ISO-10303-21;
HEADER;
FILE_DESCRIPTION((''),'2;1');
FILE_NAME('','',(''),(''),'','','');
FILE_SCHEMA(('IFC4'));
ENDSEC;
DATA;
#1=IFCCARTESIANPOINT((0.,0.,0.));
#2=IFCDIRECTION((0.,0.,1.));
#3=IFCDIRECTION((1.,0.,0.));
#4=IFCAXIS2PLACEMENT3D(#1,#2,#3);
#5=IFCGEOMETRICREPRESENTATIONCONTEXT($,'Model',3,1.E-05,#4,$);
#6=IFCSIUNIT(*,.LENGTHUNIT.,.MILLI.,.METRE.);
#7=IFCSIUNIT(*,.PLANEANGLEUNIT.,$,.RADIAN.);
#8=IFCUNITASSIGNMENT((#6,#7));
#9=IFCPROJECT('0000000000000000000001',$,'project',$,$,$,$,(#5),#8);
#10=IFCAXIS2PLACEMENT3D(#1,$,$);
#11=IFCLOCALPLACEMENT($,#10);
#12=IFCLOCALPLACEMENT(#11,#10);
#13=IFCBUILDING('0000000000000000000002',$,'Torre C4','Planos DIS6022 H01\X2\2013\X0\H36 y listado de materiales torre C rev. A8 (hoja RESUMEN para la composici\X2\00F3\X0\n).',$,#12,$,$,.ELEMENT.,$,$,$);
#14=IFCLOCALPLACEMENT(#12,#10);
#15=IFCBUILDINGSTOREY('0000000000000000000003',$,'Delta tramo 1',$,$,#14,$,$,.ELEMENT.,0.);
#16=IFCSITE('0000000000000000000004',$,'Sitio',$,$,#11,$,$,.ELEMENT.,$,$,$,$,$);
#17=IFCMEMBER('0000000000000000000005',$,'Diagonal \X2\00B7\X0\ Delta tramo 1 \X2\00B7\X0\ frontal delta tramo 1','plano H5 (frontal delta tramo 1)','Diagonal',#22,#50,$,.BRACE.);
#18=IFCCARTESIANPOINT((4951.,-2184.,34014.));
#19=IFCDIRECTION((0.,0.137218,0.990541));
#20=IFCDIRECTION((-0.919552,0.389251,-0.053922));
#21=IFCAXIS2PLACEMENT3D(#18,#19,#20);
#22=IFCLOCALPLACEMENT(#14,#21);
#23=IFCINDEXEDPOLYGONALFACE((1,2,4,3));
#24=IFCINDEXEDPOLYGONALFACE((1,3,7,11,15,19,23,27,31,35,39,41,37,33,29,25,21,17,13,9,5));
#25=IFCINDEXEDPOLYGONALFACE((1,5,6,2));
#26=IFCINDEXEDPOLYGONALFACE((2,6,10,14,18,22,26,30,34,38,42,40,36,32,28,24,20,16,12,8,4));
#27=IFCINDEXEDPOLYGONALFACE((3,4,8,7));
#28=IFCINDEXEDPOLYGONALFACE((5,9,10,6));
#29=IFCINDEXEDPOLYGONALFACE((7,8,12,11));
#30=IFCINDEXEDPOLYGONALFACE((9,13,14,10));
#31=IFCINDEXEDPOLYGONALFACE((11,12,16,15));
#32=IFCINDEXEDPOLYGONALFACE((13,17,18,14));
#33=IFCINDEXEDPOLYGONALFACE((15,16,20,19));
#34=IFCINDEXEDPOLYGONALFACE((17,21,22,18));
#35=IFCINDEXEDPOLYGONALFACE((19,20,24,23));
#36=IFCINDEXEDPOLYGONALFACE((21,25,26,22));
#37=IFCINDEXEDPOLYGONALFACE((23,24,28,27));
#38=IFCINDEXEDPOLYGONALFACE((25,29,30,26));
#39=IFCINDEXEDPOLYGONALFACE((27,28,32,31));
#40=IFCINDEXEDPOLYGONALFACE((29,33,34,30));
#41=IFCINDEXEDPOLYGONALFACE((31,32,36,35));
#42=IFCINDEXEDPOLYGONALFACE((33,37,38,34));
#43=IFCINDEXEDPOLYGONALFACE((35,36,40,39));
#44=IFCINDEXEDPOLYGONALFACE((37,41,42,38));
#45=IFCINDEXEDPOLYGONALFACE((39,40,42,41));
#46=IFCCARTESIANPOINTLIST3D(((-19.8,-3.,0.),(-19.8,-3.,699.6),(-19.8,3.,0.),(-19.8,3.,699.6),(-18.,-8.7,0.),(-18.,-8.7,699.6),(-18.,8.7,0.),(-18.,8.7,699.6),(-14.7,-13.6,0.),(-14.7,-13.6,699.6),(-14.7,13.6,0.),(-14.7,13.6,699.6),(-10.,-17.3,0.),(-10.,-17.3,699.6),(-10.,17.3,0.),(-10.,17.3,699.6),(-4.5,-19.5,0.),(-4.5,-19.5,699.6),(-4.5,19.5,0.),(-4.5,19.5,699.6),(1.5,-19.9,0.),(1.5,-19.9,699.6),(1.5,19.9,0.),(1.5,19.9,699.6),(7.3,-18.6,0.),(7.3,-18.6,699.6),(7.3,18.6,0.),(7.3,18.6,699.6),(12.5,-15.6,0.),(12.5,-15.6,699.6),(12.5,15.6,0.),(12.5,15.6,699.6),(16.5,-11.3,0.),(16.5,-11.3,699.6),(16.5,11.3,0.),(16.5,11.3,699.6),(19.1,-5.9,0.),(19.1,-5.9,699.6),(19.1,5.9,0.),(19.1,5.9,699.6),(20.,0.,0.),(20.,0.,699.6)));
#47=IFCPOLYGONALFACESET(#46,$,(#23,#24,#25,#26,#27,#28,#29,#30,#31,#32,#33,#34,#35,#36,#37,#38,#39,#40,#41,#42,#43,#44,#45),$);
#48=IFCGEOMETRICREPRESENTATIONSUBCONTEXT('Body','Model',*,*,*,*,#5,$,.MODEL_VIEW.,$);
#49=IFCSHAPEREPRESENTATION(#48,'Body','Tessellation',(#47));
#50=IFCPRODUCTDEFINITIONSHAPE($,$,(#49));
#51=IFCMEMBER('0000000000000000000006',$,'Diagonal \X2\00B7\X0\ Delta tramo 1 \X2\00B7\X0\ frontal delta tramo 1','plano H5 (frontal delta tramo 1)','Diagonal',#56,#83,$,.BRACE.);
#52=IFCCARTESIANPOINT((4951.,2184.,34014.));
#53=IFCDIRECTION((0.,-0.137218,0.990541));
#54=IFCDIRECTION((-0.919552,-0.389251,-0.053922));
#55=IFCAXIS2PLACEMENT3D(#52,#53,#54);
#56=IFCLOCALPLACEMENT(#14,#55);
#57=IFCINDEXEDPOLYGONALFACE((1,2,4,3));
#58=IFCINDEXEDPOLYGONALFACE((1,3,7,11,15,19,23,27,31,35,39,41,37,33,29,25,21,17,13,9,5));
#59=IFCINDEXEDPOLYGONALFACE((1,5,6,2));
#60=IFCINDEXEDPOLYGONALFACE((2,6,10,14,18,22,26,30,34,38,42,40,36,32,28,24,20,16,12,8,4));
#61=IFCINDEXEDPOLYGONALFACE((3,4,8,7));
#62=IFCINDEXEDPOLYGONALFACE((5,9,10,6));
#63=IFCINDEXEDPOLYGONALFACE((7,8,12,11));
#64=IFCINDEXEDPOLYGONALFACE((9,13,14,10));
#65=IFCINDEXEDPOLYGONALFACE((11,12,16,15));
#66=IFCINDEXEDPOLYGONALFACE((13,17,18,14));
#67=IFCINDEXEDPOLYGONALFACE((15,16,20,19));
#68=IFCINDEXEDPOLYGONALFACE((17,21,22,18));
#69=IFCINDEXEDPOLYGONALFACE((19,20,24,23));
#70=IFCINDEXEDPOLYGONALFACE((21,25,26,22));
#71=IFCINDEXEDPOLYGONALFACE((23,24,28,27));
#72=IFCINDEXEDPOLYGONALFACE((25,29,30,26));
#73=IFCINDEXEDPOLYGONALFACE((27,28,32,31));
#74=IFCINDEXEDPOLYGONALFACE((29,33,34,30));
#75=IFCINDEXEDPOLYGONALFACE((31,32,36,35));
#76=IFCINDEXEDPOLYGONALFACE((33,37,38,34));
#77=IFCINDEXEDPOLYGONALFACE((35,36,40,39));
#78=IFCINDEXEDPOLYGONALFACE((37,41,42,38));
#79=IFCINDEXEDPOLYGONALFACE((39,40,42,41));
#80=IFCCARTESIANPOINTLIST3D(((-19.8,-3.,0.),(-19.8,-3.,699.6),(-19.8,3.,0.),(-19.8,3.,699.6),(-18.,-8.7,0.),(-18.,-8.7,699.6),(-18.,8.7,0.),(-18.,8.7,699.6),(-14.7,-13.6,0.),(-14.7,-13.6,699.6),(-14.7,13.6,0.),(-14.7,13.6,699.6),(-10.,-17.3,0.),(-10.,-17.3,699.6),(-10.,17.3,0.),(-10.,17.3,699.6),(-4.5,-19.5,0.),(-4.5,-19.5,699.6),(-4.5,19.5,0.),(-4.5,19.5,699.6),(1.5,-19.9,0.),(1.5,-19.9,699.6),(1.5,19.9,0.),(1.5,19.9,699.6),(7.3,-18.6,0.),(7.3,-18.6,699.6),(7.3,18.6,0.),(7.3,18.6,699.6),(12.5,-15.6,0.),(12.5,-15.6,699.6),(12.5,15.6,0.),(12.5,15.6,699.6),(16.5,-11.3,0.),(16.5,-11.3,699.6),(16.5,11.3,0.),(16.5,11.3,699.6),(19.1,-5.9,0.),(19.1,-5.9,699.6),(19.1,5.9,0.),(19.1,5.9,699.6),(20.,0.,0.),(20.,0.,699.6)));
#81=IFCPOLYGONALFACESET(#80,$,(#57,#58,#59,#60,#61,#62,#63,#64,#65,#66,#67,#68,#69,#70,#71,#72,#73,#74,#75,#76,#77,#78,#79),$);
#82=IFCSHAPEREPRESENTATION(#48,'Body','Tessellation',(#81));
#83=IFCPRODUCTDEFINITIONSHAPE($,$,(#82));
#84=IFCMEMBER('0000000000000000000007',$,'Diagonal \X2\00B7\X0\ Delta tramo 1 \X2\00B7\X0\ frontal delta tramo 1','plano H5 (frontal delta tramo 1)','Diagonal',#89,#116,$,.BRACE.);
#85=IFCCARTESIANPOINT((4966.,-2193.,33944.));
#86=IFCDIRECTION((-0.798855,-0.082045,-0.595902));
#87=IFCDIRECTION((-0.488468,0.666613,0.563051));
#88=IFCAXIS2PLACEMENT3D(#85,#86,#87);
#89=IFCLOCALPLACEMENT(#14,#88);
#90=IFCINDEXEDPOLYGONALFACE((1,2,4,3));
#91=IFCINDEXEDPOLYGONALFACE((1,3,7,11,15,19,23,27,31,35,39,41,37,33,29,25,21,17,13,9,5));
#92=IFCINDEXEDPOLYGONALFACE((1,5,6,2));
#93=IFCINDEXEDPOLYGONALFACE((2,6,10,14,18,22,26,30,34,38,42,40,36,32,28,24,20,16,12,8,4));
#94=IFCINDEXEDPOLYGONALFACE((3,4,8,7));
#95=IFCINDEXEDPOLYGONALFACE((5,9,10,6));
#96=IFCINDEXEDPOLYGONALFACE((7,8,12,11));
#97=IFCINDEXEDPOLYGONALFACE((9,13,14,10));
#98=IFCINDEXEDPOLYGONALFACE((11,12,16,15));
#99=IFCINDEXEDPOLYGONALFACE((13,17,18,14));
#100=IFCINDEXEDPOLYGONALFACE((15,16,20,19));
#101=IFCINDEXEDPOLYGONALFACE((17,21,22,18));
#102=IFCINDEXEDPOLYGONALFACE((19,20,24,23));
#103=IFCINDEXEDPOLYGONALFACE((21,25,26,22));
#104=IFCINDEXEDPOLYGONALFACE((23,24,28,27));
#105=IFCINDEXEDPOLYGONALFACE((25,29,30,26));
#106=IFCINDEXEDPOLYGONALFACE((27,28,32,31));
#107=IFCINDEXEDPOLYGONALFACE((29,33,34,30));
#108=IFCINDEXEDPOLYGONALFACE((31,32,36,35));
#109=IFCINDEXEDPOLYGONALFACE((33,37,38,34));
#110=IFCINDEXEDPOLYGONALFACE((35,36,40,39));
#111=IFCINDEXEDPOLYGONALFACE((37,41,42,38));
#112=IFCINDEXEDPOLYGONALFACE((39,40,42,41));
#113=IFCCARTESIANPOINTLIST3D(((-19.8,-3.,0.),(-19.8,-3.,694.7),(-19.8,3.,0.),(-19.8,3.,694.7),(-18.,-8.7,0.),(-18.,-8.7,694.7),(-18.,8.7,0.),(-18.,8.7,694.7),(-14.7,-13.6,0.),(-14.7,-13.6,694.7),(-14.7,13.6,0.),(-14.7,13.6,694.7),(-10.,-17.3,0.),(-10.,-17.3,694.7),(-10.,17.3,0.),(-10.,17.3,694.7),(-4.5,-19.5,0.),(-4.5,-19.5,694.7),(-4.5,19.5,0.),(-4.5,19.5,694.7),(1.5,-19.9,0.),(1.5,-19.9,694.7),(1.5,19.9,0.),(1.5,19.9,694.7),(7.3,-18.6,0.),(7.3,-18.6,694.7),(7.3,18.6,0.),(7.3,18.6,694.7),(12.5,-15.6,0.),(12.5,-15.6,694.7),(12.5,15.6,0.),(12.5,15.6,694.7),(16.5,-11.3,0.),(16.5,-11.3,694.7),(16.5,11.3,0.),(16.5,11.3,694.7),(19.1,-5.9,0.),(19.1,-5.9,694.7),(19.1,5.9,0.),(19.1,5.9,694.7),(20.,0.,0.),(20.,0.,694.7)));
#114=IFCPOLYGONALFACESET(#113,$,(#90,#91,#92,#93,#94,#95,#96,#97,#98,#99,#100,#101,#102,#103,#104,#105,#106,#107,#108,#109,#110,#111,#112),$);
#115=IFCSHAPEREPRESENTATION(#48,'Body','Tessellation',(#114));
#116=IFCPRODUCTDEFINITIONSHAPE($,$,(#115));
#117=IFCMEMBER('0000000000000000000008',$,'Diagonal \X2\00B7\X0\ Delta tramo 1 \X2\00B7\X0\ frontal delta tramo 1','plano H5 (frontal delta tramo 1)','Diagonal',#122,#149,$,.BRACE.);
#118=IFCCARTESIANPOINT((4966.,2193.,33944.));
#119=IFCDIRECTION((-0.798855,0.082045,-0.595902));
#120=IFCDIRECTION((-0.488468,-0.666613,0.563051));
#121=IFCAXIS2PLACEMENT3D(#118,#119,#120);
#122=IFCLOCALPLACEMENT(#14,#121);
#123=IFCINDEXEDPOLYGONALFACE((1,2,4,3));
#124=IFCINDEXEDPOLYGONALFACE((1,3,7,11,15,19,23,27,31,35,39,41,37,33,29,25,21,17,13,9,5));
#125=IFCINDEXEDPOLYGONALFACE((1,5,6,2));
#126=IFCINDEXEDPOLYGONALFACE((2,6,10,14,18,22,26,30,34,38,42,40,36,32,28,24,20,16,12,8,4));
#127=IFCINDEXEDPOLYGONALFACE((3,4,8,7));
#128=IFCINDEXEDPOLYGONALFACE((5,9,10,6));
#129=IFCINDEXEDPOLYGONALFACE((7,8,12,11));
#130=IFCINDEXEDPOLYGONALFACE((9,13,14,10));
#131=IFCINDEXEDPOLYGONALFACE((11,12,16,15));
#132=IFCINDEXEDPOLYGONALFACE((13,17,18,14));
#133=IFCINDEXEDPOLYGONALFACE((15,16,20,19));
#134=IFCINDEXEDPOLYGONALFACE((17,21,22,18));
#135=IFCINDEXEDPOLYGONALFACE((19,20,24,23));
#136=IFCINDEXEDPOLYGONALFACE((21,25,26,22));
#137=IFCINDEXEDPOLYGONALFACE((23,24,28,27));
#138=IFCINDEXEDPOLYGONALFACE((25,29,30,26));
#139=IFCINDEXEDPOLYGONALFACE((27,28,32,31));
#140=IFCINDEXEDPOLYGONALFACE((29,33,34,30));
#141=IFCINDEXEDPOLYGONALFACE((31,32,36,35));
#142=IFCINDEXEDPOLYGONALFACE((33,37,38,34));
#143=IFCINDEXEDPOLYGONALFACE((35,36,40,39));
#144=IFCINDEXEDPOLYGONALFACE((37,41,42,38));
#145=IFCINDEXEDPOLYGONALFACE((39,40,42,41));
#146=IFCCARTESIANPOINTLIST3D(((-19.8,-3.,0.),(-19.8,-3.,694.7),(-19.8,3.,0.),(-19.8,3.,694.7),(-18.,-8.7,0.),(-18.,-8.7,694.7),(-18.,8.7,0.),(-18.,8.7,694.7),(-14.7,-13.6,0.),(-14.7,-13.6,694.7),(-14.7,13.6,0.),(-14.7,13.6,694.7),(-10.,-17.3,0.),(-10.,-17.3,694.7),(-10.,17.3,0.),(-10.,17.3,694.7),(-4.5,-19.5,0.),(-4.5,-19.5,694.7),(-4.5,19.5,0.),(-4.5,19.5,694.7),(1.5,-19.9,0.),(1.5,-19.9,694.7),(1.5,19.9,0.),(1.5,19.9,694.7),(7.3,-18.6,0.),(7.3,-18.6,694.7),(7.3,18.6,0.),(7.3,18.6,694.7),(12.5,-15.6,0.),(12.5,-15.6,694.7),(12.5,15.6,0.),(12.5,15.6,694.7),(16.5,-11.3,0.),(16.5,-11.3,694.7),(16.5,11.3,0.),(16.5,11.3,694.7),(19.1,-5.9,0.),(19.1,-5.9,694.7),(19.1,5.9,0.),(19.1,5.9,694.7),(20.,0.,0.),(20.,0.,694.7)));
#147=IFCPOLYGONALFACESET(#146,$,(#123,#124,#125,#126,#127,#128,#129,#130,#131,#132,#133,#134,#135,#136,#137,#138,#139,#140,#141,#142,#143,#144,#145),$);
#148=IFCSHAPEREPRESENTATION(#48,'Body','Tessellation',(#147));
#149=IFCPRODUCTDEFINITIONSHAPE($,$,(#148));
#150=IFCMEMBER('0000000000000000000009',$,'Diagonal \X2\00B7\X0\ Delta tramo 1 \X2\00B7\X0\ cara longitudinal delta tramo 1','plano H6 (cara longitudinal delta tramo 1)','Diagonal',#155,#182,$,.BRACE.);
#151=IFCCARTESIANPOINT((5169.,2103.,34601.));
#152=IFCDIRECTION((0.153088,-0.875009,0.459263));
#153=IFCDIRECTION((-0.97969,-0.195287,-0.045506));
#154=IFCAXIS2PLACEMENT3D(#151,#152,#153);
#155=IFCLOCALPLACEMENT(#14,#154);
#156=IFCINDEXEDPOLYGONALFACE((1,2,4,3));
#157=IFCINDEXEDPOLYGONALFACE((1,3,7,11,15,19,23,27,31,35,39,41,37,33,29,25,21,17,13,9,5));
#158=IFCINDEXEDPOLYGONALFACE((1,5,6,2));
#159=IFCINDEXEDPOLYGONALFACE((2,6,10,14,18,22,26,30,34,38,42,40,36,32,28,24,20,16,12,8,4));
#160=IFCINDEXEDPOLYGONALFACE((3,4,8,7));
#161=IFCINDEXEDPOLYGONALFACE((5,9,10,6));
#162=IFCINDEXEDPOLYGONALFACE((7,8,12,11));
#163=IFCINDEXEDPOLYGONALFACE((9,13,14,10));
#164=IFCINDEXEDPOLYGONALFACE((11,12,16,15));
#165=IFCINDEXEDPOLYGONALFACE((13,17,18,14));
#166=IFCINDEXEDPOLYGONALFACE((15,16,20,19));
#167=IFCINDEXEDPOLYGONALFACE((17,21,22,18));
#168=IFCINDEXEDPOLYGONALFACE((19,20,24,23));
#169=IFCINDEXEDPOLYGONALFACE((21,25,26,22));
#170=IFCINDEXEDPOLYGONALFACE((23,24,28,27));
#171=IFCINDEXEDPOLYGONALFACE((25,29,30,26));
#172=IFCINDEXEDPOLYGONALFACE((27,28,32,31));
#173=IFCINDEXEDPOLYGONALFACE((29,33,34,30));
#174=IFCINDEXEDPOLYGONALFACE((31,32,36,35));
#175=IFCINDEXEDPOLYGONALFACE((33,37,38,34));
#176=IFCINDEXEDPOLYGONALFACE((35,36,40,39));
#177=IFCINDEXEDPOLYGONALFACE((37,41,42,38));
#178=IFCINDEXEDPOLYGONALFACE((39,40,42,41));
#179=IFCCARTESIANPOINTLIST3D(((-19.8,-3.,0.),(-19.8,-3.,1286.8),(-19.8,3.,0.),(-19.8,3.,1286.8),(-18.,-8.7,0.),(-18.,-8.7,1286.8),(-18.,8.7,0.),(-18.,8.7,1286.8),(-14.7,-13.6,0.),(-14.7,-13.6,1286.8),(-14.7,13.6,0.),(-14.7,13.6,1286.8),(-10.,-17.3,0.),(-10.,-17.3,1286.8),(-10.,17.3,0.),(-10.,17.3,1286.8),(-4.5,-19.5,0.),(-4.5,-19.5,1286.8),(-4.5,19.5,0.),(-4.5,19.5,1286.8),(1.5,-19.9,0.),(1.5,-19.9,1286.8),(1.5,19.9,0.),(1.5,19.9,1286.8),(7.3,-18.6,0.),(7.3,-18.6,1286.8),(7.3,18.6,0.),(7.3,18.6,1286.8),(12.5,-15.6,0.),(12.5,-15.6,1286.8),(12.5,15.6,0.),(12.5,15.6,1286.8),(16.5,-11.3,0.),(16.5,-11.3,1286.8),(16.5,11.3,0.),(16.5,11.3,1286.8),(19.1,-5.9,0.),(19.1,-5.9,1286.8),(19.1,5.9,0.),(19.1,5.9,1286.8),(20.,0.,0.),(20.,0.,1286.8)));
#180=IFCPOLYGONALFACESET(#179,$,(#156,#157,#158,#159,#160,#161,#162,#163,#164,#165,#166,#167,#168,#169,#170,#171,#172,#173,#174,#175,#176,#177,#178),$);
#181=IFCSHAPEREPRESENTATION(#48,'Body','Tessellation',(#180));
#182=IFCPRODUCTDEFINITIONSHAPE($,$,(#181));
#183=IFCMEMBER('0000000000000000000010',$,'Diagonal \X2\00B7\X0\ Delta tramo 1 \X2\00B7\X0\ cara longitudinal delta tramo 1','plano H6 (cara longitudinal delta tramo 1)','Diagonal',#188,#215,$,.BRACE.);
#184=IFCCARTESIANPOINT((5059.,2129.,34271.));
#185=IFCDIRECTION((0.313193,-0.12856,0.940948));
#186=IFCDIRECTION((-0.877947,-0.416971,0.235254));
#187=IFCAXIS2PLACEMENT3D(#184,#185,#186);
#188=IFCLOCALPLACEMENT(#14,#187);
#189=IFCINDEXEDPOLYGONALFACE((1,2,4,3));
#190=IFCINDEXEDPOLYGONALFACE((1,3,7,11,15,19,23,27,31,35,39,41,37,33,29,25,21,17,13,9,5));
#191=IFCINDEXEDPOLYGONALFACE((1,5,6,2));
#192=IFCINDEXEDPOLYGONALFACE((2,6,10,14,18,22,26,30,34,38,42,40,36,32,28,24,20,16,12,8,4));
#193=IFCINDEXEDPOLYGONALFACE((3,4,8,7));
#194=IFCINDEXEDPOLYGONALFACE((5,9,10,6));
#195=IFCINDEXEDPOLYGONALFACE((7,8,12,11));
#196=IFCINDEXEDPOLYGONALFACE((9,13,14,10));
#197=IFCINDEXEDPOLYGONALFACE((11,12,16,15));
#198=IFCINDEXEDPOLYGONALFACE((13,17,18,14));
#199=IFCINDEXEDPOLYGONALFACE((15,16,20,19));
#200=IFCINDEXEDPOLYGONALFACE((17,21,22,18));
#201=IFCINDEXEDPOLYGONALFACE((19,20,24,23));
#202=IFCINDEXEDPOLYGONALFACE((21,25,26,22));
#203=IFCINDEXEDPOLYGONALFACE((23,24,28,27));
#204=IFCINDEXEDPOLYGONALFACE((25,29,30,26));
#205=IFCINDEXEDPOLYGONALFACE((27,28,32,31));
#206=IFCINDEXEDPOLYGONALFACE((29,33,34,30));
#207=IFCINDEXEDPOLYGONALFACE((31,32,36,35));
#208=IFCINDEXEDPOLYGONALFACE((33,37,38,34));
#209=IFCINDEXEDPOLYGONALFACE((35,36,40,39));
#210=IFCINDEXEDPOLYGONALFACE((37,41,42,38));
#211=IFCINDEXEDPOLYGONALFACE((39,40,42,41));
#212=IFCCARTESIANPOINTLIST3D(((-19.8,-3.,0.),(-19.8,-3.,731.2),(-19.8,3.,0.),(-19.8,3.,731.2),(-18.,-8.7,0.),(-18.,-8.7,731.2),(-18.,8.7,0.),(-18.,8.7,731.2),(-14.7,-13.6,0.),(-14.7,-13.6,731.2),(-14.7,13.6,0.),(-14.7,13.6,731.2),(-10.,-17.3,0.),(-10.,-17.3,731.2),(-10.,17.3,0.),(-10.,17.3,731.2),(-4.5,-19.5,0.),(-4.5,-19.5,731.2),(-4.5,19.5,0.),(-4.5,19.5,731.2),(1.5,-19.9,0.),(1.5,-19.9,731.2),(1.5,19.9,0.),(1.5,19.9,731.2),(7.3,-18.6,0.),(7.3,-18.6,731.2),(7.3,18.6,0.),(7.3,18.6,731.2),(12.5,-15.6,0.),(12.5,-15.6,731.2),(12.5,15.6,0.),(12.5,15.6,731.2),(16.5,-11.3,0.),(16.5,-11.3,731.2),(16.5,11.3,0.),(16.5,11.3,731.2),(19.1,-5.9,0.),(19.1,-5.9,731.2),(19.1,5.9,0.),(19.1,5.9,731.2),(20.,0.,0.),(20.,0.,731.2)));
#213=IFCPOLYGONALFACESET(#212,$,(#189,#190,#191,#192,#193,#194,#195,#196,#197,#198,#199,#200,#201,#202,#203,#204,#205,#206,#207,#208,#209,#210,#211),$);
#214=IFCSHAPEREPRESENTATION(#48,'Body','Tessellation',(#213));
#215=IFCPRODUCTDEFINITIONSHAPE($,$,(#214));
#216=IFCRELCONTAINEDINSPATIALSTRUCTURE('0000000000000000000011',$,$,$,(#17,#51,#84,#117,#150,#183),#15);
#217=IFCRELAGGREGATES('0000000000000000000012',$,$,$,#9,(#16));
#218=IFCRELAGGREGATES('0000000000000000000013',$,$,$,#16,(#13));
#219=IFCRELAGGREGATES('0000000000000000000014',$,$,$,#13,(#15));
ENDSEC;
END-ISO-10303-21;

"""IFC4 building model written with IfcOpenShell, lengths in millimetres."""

from ifc_helpers import new_model, si_unit, frame, origin, origin_with_axes, place, context, subcontext, project, spatial, circle, extrude, element, save


model = new_model("IFC4")

# Units and contexts
model_context = context("Model", 3, precision=1e-05, world=origin_with_axes())
body_context = subcontext(model_context, "Body", "Model", "MODEL_VIEW")
ifc_project = project(units=[si_unit("LENGTHUNIT", "METRE", prefix="MILLI"), si_unit("PLANEANGLEUNIT", "RADIAN")], contexts=[model_context])

# Site, building, storey
site_placement = place(None, origin())
site = spatial("IfcSite", under=ifc_project, at=site_placement, Name="Sitio", CompositionType="ELEMENT")
building_placement = place(site_placement, origin())
building = spatial("IfcBuilding", under=site, at=building_placement, Name="Torre C4", Description="Planos DIS6022 H01–H36 y listado de materiales torre C rev. A8 (hoja RESUMEN para la composición).", CompositionType="ELEMENT")
storey_placement = place(building_placement, origin())
storey = spatial("IfcBuildingStorey", under=building, at=storey_placement, Name="Delta tramo 1", CompositionType="ELEMENT", Elevation=0.0)

# Members
for number, where, z_axis, x_axis, name in (
    (1, (4951.0, -2184.0, 34014.0), (0.0, 0.137218, 0.990541), (-0.919552, 0.389251, -0.053922), "Diagonal · Delta tramo 1 · frontal delta tramo 1"),
    (2, (4951.0, 2184.0, 34014.0), (0.0, -0.137218, 0.990541), (-0.919552, -0.389251, -0.053922), "Diagonal · Delta tramo 1 · frontal delta tramo 1"),
):
    element("IfcMember", number, at=place(storey_placement, frame(where, z_axis=z_axis, x_axis=x_axis)), inside=storey, Name=name, Description="plano H5 (frontal delta tramo 1)", ObjectType="Diagonal", PredefinedType="BRACE", context=body_context, shape_type="SweptSolid", body=[
        extrude(circle(Radius=20.0), None, (0.0, 0.0, 1.0), 699.6),
    ])
for number, where, z_axis, x_axis, name in (
    (3, (4966.0, -2193.0, 33944.0), (-0.798855, -0.082045, -0.595902), (-0.488468, 0.666613, 0.563051), "Diagonal · Delta tramo 1 · frontal delta tramo 1"),
    (4, (4966.0, 2193.0, 33944.0), (-0.798855, 0.082045, -0.595902), (-0.488468, -0.666613, 0.563051), "Diagonal · Delta tramo 1 · frontal delta tramo 1"),
):
    element("IfcMember", number, at=place(storey_placement, frame(where, z_axis=z_axis, x_axis=x_axis)), inside=storey, Name=name, Description="plano H5 (frontal delta tramo 1)", ObjectType="Diagonal", PredefinedType="BRACE", context=body_context, shape_type="SweptSolid", body=[
        extrude(circle(Radius=20.0), None, (0.0, 0.0, 1.0), 694.7),
    ])
member_1_placement = place(storey_placement, frame((5169.0, 2103.0, 34601.0), z_axis=(0.153088, -0.875009, 0.459263), x_axis=(-0.97969, -0.195287, -0.045506)))
element("IfcMember", 5, at=member_1_placement, inside=storey, Name="Diagonal · Delta tramo 1 · cara longitudinal delta tramo 1", Description="plano H6 (cara longitudinal delta tramo 1)", ObjectType="Diagonal", PredefinedType="BRACE", context=body_context, shape_type="SweptSolid", body=[
    extrude(circle(Radius=20.0), None, (0.0, 0.0, 1.0), 1286.8),
])
member_2_placement = place(storey_placement, frame((5059.0, 2129.0, 34271.0), z_axis=(0.313193, -0.12856, 0.940948), x_axis=(-0.877947, -0.416971, 0.235254)))
element("IfcMember", 6, at=member_2_placement, inside=storey, Name="Diagonal · Delta tramo 1 · cara longitudinal delta tramo 1", Description="plano H6 (cara longitudinal delta tramo 1)", ObjectType="Diagonal", PredefinedType="BRACE", context=body_context, shape_type="SweptSolid", body=[
    extrude(circle(Radius=20.0), None, (0.0, 0.0, 1.0), 731.2),
])

save(model, "model.ifc")
